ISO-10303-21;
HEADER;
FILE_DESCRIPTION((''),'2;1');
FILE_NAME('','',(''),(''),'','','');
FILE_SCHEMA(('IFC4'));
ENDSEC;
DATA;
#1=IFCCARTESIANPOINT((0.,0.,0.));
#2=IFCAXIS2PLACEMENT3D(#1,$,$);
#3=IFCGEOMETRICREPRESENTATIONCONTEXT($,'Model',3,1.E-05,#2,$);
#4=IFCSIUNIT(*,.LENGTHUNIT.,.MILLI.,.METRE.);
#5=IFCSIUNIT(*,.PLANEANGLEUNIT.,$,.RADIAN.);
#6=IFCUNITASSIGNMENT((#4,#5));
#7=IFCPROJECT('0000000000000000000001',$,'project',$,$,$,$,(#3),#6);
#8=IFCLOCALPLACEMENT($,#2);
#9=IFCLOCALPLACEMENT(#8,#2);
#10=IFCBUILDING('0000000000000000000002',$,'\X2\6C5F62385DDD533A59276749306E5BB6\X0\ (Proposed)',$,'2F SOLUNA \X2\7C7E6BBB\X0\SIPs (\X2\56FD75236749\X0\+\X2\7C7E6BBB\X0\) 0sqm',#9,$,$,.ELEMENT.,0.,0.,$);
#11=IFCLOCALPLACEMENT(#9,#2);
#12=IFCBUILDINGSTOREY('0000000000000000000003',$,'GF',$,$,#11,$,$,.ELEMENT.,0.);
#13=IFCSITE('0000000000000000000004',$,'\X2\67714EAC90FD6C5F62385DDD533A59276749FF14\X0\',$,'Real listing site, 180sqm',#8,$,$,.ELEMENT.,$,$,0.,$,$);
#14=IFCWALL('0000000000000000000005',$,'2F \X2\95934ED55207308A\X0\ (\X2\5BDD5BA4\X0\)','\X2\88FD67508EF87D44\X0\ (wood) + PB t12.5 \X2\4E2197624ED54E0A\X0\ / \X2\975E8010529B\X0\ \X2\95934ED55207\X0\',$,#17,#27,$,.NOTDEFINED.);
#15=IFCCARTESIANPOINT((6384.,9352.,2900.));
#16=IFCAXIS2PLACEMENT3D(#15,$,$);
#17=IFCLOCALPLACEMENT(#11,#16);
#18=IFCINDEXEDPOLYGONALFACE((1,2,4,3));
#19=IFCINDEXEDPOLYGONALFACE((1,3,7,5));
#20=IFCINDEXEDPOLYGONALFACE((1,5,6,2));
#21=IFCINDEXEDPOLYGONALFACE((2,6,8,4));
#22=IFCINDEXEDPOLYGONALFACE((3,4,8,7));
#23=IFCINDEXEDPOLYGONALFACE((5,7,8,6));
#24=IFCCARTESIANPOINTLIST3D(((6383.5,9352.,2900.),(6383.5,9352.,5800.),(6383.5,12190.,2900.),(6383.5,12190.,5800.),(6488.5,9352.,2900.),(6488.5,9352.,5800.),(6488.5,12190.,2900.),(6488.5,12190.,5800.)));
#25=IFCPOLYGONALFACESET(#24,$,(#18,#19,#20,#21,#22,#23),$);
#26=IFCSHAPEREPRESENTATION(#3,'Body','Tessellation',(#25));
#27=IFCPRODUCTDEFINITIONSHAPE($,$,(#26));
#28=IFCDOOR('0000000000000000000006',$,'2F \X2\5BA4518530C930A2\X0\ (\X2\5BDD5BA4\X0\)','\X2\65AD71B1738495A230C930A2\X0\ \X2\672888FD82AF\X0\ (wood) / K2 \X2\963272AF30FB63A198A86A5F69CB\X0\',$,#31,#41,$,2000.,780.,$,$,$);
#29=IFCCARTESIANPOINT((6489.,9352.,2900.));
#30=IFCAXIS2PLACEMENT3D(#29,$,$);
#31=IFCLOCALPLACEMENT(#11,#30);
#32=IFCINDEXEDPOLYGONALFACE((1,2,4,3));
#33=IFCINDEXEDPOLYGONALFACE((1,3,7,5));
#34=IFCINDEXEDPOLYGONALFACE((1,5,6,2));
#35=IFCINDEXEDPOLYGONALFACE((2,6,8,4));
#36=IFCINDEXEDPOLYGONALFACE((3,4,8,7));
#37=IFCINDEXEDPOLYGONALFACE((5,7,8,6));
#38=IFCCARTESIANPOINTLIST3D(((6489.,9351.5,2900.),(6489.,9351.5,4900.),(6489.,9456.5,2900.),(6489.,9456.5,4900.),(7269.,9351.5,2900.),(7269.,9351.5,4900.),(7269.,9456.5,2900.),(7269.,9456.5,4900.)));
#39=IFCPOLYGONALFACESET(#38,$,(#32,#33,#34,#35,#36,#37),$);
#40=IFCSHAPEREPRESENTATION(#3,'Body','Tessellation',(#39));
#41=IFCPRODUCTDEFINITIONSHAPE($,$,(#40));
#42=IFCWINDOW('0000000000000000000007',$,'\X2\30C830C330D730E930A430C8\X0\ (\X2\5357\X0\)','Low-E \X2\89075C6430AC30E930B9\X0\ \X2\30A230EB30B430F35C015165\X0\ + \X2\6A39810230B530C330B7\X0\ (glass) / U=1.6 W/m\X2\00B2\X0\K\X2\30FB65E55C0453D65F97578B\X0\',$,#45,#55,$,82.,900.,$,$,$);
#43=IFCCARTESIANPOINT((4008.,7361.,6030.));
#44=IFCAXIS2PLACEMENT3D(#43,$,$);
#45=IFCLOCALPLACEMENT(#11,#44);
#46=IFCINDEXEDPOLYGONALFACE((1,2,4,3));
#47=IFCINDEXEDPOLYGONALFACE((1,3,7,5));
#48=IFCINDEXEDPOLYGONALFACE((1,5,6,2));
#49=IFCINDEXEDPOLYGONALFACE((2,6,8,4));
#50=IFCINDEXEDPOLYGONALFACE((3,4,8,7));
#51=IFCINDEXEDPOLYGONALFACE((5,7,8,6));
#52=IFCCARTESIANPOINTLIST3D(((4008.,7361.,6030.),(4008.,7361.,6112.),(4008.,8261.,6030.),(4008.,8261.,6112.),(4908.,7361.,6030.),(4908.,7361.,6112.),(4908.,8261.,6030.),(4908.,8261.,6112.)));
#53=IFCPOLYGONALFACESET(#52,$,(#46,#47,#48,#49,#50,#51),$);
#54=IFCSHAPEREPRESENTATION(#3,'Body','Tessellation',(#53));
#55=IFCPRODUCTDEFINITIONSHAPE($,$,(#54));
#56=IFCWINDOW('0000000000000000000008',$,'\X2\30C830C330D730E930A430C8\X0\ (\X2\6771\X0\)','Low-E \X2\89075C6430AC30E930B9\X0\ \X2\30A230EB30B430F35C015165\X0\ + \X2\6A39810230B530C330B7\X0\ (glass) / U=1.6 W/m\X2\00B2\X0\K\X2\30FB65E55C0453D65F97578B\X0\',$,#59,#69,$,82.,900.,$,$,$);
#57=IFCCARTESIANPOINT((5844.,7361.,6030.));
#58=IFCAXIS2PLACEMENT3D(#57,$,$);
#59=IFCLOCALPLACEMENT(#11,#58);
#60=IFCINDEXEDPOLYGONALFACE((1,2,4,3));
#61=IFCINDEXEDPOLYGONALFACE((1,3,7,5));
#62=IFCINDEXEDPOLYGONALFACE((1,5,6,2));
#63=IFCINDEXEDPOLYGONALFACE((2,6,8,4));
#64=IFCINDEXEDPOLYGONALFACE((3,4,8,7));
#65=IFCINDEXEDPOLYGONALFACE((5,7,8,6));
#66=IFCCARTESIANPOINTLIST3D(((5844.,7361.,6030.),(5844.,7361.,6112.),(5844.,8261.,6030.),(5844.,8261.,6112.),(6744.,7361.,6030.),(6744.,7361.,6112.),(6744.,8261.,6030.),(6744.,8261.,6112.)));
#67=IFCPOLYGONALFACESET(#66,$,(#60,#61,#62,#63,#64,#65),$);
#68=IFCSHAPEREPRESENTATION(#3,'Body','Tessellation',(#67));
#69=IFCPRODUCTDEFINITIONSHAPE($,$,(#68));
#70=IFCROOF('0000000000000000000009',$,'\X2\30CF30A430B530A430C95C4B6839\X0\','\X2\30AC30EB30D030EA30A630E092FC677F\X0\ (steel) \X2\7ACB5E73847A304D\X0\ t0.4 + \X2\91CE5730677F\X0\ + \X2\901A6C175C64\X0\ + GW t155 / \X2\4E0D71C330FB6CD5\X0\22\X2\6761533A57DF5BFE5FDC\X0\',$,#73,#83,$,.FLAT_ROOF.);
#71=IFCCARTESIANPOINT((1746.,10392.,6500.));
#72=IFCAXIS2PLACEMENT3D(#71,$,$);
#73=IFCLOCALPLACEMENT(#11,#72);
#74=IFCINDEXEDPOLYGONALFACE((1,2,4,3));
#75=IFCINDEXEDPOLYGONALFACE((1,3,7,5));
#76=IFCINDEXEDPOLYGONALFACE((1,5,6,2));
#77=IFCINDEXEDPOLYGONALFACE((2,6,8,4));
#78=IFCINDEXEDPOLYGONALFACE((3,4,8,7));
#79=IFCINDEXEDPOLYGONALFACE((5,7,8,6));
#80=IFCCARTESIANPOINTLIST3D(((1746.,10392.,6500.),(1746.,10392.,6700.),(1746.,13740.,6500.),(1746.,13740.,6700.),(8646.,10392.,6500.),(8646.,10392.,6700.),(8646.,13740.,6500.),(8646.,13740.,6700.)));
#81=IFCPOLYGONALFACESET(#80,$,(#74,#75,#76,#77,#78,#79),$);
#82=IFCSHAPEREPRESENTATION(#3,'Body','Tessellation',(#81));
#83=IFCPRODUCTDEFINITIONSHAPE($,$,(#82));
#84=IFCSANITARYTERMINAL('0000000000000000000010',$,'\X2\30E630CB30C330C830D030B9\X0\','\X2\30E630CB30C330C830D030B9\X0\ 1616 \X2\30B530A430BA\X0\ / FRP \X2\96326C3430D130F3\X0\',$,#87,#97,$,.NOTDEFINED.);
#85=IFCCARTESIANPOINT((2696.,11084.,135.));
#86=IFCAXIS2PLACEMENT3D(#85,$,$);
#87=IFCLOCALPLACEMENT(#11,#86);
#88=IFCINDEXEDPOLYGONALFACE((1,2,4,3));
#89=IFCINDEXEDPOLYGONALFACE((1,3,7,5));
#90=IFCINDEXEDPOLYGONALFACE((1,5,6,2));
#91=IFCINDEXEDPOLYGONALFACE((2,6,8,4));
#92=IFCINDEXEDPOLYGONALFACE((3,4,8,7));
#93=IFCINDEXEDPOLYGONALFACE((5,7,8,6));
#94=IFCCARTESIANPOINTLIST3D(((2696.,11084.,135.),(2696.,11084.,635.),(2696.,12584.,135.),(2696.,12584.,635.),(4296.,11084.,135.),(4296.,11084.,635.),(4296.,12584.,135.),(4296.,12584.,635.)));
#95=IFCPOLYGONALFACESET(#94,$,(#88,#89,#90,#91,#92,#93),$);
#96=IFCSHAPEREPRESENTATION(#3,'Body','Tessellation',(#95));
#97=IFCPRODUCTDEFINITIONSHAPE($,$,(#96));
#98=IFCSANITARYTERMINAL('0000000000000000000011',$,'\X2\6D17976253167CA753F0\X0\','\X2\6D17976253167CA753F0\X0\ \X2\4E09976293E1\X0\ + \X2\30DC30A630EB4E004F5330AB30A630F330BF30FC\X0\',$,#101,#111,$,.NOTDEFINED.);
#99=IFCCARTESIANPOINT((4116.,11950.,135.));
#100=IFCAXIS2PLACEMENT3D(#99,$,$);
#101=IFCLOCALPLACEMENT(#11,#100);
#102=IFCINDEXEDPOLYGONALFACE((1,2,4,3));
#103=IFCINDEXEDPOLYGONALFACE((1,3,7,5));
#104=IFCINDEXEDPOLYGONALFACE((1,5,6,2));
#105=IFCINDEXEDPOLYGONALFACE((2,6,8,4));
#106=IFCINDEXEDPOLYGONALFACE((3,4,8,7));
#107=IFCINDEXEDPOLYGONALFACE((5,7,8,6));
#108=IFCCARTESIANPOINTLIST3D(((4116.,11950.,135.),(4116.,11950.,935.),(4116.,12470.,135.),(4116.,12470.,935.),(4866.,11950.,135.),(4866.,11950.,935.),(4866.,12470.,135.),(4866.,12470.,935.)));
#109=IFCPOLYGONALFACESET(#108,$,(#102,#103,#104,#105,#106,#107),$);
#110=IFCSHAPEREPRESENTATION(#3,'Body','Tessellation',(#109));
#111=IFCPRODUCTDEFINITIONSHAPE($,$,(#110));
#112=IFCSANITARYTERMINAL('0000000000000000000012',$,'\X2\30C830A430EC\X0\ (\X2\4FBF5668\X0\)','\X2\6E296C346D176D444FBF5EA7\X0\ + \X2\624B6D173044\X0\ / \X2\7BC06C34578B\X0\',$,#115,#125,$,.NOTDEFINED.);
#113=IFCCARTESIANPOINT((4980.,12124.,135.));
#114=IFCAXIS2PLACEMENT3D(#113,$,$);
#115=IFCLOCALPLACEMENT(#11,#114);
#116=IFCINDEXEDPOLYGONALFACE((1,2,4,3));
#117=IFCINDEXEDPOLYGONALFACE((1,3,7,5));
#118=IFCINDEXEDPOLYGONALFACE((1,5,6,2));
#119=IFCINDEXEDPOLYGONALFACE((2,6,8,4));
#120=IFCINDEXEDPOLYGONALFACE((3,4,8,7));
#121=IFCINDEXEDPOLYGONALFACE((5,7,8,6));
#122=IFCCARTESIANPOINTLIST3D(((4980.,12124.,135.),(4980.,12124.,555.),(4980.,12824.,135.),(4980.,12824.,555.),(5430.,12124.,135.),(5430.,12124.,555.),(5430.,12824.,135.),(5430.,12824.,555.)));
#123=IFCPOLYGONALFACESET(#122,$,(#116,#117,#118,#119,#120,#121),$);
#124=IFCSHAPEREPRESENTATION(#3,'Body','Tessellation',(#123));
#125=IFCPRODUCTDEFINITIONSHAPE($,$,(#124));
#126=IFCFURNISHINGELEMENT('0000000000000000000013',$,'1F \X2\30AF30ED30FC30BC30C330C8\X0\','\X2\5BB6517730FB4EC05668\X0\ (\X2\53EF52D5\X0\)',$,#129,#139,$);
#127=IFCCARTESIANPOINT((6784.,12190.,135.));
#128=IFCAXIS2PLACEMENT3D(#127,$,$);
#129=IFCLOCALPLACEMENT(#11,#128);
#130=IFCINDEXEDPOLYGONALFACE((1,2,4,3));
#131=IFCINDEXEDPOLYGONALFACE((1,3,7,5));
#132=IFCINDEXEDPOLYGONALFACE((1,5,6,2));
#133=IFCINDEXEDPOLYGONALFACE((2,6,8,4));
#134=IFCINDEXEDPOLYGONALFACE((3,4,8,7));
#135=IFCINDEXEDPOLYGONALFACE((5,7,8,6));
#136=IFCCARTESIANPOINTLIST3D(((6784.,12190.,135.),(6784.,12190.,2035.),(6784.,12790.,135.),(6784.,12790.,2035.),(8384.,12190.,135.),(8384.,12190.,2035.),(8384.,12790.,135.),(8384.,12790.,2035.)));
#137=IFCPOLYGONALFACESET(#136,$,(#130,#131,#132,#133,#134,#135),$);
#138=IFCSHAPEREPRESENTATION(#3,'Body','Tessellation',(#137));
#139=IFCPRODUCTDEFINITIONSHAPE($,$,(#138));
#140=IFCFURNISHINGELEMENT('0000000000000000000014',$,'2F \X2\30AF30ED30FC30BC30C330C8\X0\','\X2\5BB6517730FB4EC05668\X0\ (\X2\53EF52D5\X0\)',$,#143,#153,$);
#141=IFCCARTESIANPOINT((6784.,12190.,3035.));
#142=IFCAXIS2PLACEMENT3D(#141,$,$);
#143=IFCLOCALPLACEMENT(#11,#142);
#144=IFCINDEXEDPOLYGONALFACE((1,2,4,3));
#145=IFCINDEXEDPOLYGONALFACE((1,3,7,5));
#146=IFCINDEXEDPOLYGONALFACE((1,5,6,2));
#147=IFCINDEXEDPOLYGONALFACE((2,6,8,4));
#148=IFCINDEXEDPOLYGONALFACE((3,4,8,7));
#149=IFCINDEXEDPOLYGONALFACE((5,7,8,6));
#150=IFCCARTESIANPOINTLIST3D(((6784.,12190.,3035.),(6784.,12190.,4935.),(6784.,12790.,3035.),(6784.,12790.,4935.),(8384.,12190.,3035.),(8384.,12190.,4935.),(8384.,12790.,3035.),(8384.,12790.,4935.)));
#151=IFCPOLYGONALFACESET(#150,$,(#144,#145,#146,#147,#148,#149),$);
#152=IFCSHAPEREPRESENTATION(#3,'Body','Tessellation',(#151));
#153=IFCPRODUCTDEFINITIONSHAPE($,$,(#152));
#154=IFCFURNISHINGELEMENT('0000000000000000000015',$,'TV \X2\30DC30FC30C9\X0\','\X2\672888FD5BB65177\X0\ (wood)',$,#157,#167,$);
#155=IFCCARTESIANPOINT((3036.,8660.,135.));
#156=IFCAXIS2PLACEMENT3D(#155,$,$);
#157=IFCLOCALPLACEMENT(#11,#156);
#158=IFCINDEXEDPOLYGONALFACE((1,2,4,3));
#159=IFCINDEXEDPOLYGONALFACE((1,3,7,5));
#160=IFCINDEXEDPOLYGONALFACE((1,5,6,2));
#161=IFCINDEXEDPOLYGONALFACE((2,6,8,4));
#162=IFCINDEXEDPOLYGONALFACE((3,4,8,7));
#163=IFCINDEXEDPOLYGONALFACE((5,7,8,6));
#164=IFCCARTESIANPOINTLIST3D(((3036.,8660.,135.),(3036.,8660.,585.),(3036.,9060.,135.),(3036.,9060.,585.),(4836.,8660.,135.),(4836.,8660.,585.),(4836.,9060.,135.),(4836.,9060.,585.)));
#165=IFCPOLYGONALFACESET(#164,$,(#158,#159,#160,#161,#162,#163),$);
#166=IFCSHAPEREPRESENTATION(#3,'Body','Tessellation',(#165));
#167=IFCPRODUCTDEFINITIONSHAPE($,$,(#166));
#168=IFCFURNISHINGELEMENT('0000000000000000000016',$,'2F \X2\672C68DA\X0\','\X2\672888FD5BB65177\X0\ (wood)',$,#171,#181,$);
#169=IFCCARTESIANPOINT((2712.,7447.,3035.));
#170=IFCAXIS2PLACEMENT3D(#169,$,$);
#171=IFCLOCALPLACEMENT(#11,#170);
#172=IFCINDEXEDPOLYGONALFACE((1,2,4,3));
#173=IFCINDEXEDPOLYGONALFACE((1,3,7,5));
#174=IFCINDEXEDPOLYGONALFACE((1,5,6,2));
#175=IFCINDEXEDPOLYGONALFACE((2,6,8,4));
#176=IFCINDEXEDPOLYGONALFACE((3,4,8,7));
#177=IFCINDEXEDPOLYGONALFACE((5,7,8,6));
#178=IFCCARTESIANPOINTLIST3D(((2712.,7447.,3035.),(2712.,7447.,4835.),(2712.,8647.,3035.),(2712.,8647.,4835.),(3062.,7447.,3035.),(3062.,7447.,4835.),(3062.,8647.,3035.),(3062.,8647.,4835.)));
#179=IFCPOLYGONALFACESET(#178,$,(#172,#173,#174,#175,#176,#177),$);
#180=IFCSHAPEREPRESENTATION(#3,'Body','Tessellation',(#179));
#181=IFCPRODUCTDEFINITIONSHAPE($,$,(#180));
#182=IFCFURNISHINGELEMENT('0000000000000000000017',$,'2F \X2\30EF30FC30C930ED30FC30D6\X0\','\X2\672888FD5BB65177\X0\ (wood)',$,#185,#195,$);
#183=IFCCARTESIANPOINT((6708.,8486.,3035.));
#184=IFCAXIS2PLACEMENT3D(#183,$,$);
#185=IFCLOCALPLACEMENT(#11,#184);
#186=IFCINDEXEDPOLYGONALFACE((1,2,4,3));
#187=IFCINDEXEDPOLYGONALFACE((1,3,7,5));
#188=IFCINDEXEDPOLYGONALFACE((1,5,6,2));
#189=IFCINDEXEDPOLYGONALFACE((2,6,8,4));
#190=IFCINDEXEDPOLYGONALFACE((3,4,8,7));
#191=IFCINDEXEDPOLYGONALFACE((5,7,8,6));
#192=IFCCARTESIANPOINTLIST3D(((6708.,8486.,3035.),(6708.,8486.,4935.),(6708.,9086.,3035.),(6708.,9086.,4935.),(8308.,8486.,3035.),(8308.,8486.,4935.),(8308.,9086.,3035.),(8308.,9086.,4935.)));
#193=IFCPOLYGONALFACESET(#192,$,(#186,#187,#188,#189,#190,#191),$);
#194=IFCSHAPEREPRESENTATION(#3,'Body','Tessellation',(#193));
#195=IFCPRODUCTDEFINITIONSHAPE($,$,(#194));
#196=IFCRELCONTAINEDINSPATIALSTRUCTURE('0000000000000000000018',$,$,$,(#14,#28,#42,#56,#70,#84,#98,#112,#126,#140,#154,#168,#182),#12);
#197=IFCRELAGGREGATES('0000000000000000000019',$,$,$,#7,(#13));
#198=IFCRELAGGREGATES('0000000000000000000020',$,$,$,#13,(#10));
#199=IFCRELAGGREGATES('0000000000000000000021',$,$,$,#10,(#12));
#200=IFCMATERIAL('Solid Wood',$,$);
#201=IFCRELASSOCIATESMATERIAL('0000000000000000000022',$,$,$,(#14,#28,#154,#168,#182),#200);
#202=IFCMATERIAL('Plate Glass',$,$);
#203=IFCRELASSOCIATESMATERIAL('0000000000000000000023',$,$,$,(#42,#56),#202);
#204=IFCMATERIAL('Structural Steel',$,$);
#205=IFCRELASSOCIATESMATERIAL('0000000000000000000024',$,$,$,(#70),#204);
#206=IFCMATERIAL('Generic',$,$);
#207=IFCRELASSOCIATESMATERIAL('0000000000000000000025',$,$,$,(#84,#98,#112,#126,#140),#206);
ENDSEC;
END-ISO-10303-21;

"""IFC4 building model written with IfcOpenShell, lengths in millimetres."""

from ifc_helpers import new_model, si_unit, frame, frame_2d, origin, place, context, project, spatial, rectangle, extrude, material, element, save


model = new_model("IFC4")

# Units and contexts
model_context = context("Model", 3, precision=1e-05, world=origin())
ifc_project = project(units=[si_unit("LENGTHUNIT", "METRE", prefix="MILLI"), si_unit("PLANEANGLEUNIT", "RADIAN")], contexts=[model_context])

# Site, building, storey
site_placement = place(None, origin())
site = spatial("IfcSite", under=ifc_project, at=site_placement, Name="東京都江戸川区大杉４", ObjectType="Real listing site, 180sqm", CompositionType="ELEMENT", RefElevation=0.0)
building_placement = place(site_placement, origin())
building = spatial("IfcBuilding", under=site, at=building_placement, Name="江戸川区大杉の家 (Proposed)", ObjectType="2F SOLUNA 籾殻SIPs (国産杉+籾殻) 0sqm", CompositionType="ELEMENT", ElevationOfRefHeight=0.0, ElevationOfTerrain=0.0)
storey_placement = place(building_placement, origin())
storey = spatial("IfcBuildingStorey", under=building, at=storey_placement, Name="GF", CompositionType="ELEMENT", Elevation=0.0)

# Shared definitions
ifc_material_1 = material(Name="Solid Wood")
ifc_material_2 = material(Name="Plate Glass")

# Wall
wall_1_placement = place(storey_placement, frame((6384.0, 9352.0, 2900.0)))
element("IfcWall", 1, at=wall_1_placement, inside=storey, material=ifc_material_1, Name="2F 間仕切り (寝室)", Description="製材軸組 (wood) + PB t12.5 両面仕上 / 非耐力 間仕切", PredefinedType="NOTDEFINED", context=model_context, shape_type="SweptSolid", body=[
    extrude(rectangle(XDim=105.0, YDim=2838.0, at=frame_2d((52.0, 1419.0))), frame((6384.0, 9352.0, 2900.0)), (0.0, 0.0, 1.0), 2900.0),
])

# Door
door_1_placement = place(storey_placement, frame((6489.0, 9352.0, 2900.0)))
element("IfcDoor", 2, at=door_1_placement, inside=storey, material=ifc_material_1, Name="2F 室内ドア (寝室)", Description="断熱玄関ドア 木製芯 (wood) / K2 防犯・採風機構", OverallHeight=2000.0, OverallWidth=780.0, context=model_context, shape_type="SweptSolid", body=[
    extrude(rectangle(XDim=780.0, YDim=105.0, at=frame_2d((390.0, 52.0))), frame((6489.0, 9352.0, 2900.0)), (0.0, 0.0, 1.0), 2000.0),
])

# Windows
window_1_placement = place(storey_placement, frame((4008.0, 7361.0, 6030.0)))
element("IfcWindow", 3, at=window_1_placement, inside=storey, material=ifc_material_2, Name="トップライト (南)", Description="Low-E 複層ガラス アルゴン封入 + 樹脂サッシ (glass) / U=1.6 W/m²K・日射取得型", OverallHeight=82.0, OverallWidth=900.0, context=model_context, shape_type="SweptSolid", body=[
    extrude(rectangle(XDim=900.0, YDim=900.0, at=frame_2d((450.0, 450.0))), frame((4008.0, 7361.0, 6030.0)), (0.0, 0.0, 1.0), 82.0),
])
window_2_placement = place(storey_placement, frame((5844.0, 7361.0, 6030.0)))
element("IfcWindow", 4, at=window_2_placement, inside=storey, material=ifc_material_2, Name="トップライト (東)", Description="Low-E 複層ガラス アルゴン封入 + 樹脂サッシ (glass) / U=1.6 W/m²K・日射取得型", OverallHeight=82.0, OverallWidth=900.0, context=model_context, shape_type="SweptSolid", body=[
    extrude(rectangle(XDim=900.0, YDim=900.0, at=frame_2d((450.0, 450.0))), frame((5844.0, 7361.0, 6030.0)), (0.0, 0.0, 1.0), 82.0),
])

# Roof
ifc_material_3 = material(Name="Structural Steel")
roof_placement = place(storey_placement, frame((1746.0, 10392.0, 6500.0)))
element("IfcRoof", 5, at=roof_placement, inside=storey, material=ifc_material_3, Name="ハイサイド屋根", Description="ガルバリウム鋼板 (steel) 立平葺き t0.4 + 野地板 + 通気層 + GW t155 / 不燃・法22条区域対応", PredefinedType="FLAT_ROOF", context=model_context, shape_type="SweptSolid", body=[
    extrude(rectangle(XDim=6900.0, YDim=3348.0, at=frame_2d((3450.0, 1674.0))), frame((1746.0, 10392.0, 6500.0)), (0.0, 0.0, 1.0), 200.0),
])

# Sanitary terminals
ifc_material_4 = material(Name="Generic")
sanitary_terminal_1_placement = place(storey_placement, frame((2696.0, 11084.0, 135.0)))
element("IfcSanitaryTerminal", 6, at=sanitary_terminal_1_placement, inside=storey, material=ifc_material_4, Name="ユニットバス", Description="ユニットバス 1616 サイズ / FRP 防水パン", PredefinedType="NOTDEFINED", context=model_context, shape_type="SweptSolid", body=[
    extrude(rectangle(XDim=1600.0, YDim=1500.0, at=frame_2d((800.0, 750.0))), frame((2696.0, 11084.0, 135.0)), (0.0, 0.0, 1.0), 500.0),
])
sanitary_terminal_2_placement = place(storey_placement, frame((4116.0, 11950.0, 135.0)))
element("IfcSanitaryTerminal", 7, at=sanitary_terminal_2_placement, inside=storey, material=ifc_material_4, Name="洗面化粧台", Description="洗面化粧台 三面鏡 + ボウル一体カウンター", PredefinedType="NOTDEFINED", context=model_context, shape_type="SweptSolid", body=[
    extrude(rectangle(XDim=750.0, YDim=520.0, at=frame_2d((375.0, 260.0))), frame((4116.0, 11950.0, 135.0)), (0.0, 0.0, 1.0), 800.0),
])
sanitary_terminal_3_placement = place(storey_placement, frame((4980.0, 12124.0, 135.0)))
element("IfcSanitaryTerminal", 8, at=sanitary_terminal_3_placement, inside=storey, material=ifc_material_4, Name="トイレ (便器)", Description="温水洗浄便座 + 手洗い / 節水型", PredefinedType="NOTDEFINED", context=model_context, shape_type="SweptSolid", body=[
    extrude(rectangle(XDim=450.0, YDim=700.0, at=frame_2d((225.0, 350.0))), frame((4980.0, 12124.0, 135.0)), (0.0, 0.0, 1.0), 420.0),
])

# Furnishing elements
furnishing_1_placement = place(storey_placement, frame((6784.0, 12190.0, 135.0)))
element("IfcFurnishingElement", 9, at=furnishing_1_placement, inside=storey, material=ifc_material_4, Name="1F クローゼット", Description="家具・什器 (可動)", context=model_context, shape_type="SweptSolid", body=[
    extrude(rectangle(XDim=1600.0, YDim=600.0, at=frame_2d((800.0, 300.0))), frame((6784.0, 12190.0, 135.0)), (0.0, 0.0, 1.0), 1900.0),
])
furnishing_2_placement = place(storey_placement, frame((6784.0, 12190.0, 3035.0)))
element("IfcFurnishingElement", 10, at=furnishing_2_placement, inside=storey, material=ifc_material_4, Name="2F クローゼット", Description="家具・什器 (可動)", context=model_context, shape_type="SweptSolid", body=[
    extrude(rectangle(XDim=1600.0, YDim=600.0, at=frame_2d((800.0, 300.0))), frame((6784.0, 12190.0, 3035.0)), (0.0, 0.0, 1.0), 1900.0),
])
furnishing_3_placement = place(storey_placement, frame((3036.0, 8660.0, 135.0)))
element("IfcFurnishingElement", 11, at=furnishing_3_placement, inside=storey, material=ifc_material_1, Name="TV ボード", Description="木製家具 (wood)", context=model_context, shape_type="SweptSolid", body=[
    extrude(rectangle(XDim=1800.0, YDim=400.0, at=frame_2d((900.0, 200.0))), frame((3036.0, 8660.0, 135.0)), (0.0, 0.0, 1.0), 450.0),
])
furnishing_4_placement = place(storey_placement, frame((2712.0, 7447.0, 3035.0)))
element("IfcFurnishingElement", 12, at=furnishing_4_placement, inside=storey, material=ifc_material_1, Name="2F 本棚", Description="木製家具 (wood)", context=model_context, shape_type="SweptSolid", body=[
    extrude(rectangle(XDim=350.0, YDim=1200.0, at=frame_2d((175.0, 600.0))), frame((2712.0, 7447.0, 3035.0)), (0.0, 0.0, 1.0), 1800.0),
])
furnishing_5_placement = place(storey_placement, frame((6708.0, 8486.0, 3035.0)))
element("IfcFurnishingElement", 13, at=furnishing_5_placement, inside=storey, material=ifc_material_1, Name="2F ワードローブ", Description="木製家具 (wood)", context=model_context, shape_type="SweptSolid", body=[
    extrude(rectangle(XDim=1600.0, YDim=600.0, at=frame_2d((800.0, 300.0))), frame((6708.0, 8486.0, 3035.0)), (0.0, 0.0, 1.0), 1900.0),
])

save(model, "model.ifc")
